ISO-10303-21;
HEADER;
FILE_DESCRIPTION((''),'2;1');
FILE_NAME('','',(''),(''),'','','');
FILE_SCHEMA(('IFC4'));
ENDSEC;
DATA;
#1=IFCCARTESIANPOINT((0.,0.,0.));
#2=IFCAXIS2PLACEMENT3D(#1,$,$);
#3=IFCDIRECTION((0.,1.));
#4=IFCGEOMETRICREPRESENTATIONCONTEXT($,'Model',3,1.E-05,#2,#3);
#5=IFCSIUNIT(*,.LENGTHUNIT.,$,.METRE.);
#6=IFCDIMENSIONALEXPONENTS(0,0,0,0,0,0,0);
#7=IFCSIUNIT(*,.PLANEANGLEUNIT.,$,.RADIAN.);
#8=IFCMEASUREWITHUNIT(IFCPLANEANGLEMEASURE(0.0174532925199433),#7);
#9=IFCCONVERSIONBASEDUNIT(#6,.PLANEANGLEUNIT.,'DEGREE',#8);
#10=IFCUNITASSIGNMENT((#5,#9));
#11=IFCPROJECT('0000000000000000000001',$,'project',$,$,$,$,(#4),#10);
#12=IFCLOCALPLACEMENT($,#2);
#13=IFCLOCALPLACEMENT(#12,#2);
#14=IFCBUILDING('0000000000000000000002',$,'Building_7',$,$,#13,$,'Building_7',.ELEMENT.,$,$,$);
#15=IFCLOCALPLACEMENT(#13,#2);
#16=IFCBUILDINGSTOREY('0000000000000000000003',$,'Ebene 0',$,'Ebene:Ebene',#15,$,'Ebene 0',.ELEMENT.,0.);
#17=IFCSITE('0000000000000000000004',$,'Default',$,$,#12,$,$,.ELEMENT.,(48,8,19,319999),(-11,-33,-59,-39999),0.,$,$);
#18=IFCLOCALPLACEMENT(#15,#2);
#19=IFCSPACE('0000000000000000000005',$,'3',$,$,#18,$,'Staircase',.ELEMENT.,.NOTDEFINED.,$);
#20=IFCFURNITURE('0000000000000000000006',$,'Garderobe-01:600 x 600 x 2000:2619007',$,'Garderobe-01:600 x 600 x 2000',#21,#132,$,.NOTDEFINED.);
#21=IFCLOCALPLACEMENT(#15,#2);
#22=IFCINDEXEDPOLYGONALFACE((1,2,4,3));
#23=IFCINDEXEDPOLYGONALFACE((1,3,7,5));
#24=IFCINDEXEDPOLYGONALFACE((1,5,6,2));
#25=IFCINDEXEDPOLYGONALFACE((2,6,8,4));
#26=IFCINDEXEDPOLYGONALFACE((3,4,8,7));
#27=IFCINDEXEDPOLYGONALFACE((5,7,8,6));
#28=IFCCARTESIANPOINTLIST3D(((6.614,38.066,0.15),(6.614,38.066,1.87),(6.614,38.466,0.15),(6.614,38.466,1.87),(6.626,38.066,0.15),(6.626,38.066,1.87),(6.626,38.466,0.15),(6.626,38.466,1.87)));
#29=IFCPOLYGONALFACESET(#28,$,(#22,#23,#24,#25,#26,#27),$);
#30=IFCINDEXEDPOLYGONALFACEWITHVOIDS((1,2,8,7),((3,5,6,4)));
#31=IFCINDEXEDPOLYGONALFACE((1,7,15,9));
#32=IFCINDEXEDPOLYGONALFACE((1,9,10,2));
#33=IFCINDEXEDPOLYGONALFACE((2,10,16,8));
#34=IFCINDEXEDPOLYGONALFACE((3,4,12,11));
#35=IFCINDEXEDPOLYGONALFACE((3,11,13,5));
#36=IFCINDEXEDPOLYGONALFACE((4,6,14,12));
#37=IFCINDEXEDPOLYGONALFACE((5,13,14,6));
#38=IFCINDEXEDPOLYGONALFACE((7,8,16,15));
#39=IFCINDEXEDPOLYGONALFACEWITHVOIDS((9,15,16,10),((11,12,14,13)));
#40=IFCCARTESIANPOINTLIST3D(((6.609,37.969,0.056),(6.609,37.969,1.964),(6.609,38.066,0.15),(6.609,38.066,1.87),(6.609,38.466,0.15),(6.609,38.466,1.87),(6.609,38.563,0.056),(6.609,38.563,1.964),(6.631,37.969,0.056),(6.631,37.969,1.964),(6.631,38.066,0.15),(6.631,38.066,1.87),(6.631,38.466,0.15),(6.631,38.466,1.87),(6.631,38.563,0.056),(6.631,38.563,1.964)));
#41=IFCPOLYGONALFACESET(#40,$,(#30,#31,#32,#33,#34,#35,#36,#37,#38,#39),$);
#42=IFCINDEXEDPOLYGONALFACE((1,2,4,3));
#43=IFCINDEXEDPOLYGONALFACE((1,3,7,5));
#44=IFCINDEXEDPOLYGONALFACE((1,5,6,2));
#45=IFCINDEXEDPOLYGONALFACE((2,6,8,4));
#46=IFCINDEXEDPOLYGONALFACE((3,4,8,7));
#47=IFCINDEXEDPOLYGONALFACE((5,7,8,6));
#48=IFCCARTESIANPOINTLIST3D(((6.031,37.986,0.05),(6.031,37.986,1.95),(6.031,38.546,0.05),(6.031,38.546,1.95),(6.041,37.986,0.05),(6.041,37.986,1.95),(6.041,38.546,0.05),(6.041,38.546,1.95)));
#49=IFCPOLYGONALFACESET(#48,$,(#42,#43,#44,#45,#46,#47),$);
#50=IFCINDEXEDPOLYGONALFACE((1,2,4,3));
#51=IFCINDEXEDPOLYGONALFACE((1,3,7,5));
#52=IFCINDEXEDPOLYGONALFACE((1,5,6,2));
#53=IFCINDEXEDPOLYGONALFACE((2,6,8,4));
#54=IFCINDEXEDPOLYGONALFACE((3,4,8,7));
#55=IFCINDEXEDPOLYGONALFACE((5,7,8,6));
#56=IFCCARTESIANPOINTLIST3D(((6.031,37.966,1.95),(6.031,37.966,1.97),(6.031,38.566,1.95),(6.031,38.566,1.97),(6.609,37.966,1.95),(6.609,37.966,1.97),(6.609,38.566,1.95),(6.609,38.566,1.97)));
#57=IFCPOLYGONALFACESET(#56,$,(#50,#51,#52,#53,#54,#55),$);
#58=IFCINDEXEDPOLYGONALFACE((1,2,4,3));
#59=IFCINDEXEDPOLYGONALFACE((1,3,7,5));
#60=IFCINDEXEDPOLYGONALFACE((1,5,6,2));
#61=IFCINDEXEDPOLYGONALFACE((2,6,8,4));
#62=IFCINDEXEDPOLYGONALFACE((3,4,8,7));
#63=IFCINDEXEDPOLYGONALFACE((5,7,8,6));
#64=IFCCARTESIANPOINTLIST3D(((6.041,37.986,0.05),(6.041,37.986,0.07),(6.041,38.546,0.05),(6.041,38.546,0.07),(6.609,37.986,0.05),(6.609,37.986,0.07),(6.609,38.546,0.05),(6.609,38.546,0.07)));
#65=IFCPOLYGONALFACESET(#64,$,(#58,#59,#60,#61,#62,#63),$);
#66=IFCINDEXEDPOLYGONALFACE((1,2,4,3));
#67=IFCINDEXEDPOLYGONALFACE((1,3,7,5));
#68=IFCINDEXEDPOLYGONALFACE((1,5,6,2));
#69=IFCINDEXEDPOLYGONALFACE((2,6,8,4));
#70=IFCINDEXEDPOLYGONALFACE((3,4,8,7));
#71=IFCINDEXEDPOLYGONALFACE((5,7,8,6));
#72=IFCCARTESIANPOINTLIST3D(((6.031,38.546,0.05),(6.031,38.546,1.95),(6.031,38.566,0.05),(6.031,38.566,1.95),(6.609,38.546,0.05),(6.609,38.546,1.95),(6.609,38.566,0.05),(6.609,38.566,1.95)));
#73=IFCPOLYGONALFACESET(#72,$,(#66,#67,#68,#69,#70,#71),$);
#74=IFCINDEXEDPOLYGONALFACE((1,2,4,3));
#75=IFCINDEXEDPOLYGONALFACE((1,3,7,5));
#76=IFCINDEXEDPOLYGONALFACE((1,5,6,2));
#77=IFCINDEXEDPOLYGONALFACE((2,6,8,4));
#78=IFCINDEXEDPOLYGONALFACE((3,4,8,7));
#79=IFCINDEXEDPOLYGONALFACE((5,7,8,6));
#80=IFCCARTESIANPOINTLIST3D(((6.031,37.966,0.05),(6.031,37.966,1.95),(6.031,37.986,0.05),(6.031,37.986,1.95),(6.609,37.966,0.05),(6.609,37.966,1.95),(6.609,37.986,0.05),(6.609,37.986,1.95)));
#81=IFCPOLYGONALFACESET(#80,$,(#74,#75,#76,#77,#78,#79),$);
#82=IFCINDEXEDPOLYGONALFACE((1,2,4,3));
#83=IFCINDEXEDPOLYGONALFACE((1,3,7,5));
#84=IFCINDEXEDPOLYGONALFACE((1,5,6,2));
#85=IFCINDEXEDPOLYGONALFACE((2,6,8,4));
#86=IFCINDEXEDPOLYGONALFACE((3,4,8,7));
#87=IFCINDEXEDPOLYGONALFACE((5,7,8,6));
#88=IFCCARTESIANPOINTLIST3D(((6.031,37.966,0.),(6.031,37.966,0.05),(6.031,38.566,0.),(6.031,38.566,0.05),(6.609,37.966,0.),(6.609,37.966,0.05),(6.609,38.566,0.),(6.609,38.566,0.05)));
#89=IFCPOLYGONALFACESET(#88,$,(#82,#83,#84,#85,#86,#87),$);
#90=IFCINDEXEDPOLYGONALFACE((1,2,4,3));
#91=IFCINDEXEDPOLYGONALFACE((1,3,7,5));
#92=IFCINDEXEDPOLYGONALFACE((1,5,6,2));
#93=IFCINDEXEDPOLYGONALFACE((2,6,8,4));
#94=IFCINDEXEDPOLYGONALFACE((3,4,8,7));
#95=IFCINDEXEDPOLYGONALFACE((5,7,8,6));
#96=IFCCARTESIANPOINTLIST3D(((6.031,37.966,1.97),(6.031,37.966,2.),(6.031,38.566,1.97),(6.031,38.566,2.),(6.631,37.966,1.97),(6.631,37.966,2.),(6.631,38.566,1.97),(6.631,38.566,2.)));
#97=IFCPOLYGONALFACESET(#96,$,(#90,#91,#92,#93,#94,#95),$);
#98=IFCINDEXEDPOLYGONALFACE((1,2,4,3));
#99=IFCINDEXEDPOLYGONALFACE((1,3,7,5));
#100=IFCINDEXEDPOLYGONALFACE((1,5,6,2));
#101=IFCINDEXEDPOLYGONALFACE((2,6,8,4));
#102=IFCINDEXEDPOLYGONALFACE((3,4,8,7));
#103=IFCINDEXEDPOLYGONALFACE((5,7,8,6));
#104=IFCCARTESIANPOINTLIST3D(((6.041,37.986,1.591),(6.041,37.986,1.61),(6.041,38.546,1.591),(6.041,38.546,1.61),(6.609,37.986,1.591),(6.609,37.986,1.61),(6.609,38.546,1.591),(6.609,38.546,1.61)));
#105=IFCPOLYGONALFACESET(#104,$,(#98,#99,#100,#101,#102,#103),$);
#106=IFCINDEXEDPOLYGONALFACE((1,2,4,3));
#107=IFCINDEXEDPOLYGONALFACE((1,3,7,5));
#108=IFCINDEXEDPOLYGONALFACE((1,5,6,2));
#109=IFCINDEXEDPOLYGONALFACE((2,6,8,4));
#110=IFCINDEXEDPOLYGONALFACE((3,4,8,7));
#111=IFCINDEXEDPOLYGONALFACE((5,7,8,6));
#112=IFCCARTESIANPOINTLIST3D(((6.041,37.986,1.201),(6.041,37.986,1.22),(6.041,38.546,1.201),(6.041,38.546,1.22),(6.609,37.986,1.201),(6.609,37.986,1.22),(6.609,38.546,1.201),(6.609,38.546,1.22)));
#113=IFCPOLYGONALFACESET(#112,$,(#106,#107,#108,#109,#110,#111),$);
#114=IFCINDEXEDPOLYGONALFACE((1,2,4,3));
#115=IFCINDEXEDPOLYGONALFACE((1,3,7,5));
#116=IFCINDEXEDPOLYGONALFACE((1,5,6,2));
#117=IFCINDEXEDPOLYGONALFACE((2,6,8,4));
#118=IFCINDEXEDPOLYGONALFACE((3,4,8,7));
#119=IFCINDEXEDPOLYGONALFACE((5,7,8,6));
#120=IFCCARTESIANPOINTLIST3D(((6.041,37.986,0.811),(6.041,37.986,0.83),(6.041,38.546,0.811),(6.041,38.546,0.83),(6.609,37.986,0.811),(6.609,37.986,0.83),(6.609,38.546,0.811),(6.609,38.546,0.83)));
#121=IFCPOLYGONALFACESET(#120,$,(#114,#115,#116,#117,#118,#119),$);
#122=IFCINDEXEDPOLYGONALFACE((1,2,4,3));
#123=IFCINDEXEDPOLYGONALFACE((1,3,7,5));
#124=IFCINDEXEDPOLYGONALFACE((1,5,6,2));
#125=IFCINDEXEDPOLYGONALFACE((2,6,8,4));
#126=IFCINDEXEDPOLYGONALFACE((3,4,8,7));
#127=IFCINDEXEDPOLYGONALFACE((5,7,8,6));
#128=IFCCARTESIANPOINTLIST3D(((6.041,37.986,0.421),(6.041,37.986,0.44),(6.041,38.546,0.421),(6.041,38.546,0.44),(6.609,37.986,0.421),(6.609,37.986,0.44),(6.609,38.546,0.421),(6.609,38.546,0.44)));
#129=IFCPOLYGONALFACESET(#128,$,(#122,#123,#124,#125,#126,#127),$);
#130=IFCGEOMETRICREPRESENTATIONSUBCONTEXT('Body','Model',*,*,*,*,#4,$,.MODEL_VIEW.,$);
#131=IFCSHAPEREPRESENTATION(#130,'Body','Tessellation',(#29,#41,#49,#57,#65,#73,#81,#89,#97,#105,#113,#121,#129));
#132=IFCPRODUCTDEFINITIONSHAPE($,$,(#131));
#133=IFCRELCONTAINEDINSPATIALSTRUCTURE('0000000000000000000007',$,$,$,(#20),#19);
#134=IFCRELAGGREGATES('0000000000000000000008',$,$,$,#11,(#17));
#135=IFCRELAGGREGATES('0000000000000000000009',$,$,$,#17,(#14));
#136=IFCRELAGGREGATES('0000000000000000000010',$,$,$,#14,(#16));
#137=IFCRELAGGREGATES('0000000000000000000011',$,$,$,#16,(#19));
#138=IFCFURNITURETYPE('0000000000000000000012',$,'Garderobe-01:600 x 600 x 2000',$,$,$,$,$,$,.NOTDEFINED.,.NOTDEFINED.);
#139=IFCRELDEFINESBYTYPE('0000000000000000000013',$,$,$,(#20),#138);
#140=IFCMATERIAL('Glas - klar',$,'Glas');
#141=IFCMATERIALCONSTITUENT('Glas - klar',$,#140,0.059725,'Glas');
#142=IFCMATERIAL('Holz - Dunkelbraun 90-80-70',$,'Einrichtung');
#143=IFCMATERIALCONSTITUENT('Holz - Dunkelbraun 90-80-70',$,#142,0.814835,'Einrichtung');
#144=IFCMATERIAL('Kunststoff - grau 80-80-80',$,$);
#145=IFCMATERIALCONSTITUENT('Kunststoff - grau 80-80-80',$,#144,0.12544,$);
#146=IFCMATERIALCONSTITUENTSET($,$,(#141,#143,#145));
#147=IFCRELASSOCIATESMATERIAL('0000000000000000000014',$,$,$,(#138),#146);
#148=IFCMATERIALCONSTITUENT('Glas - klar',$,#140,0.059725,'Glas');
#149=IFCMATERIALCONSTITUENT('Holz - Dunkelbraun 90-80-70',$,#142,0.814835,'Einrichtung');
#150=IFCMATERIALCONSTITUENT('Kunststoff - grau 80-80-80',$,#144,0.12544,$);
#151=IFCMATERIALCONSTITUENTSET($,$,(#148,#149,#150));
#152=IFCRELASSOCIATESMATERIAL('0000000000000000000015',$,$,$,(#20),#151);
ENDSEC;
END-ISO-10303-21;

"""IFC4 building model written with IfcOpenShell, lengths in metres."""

from ifc_helpers import new_model, entity, si_unit, converted_unit, direction, frame, origin, place, context, subcontext, project, spatial, indexed_curve, outline, extrude, source, transform, mapped, material, constituent, constituent_set, type_object, type_shapes, element, save


model = new_model("IFC4")

# Units and contexts
model_context = context("Model", 3, precision=1e-05, world=origin(), true_north=direction((0.0, 1.0)))
body_context = subcontext(model_context, "Body", "Model", "MODEL_VIEW")
ifc_project = project(units=[si_unit("LENGTHUNIT", "METRE"), converted_unit("PLANEANGLEUNIT", "DEGREE", entity("IfcPlaneAngleMeasure", 0.0174532925199433), si_unit("PLANEANGLEUNIT", "RADIAN"), dimensions=[0, 0, 0, 0, 0, 0, 0])], contexts=[model_context])

# Site, building, storey
site_placement = place(None, origin())
site = spatial("IfcSite", under=ifc_project, at=site_placement, Name="Default", CompositionType="ELEMENT", RefLatitude=(48, 8, 19, 319999), RefLongitude=(-11, -33, -59, -39999), RefElevation=0.0)
building_placement = place(site_placement, origin())
building = spatial("IfcBuilding", under=site, at=building_placement, Name="Building_7", LongName="Building_7", CompositionType="ELEMENT")
storey_placement = place(building_placement, origin())
storey = spatial("IfcBuildingStorey", under=building, at=storey_placement, Name="Ebene 0", ObjectType="Ebene:Ebene", LongName="Ebene 0", CompositionType="ELEMENT", Elevation=0.0)

# Shared definitions
ifc_material_1 = material(Name="Glas - klar", Category="Glas")
ifc_material_2 = material(Name="Holz - Dunkelbraun 90-80-70", Category="Einrichtung")
ifc_material_3 = material(Name="Kunststoff - grau 80-80-80")
ifc_constituent_1 = constituent(ifc_material_1, Name="Glas - klar", Category="Glas", fraction=0.059725)
ifc_constituent_2 = constituent(ifc_material_2, Name="Holz - Dunkelbraun 90-80-70", Category="Einrichtung", fraction=0.814835)
ifc_constituent_3 = constituent(ifc_material_3, Name="Kunststoff - grau 80-80-80", fraction=0.12544)
ifc_constituent_set_1 = constituent_set(constituents=[ifc_constituent_1, ifc_constituent_2, ifc_constituent_3])
furniture_type_1 = type_object("IfcFurnitureType", Name="Garderobe-01:600 x 600 x 2000", AssemblyPlace="NOTDEFINED", PredefinedType="NOTDEFINED", material=ifc_constituent_set_1)
shared_shape_1 = source(origin(), body_context, "Body", "SweptSolid", [
    extrude(outline(indexed_curve([(-0.006, -0.2), (0.006, -0.2), (0.006, 0.2), (-0.006, 0.2), (-0.006, -0.2)], self_intersect=False)), frame((0.0, -0.289, 0.15), z_axis=(0.0, 0.0, 1.0), x_axis=(0.0, 1.0, 0.0)), (0.0, 0.0, 1.0), 1.72),
    extrude(outline(indexed_curve([(-0.954, -0.297), (0.954, -0.297), (0.954, 0.297), (-0.954, 0.297), (-0.954, -0.297)], self_intersect=False), holes=[indexed_curve([(-0.86, 0.2), (0.86, 0.2), (0.86, -0.2), (-0.86, -0.2), (-0.86, 0.2)], self_intersect=False)]), frame((0.0, -0.3, 1.01), z_axis=(0.0, 1.0, 0.0), x_axis=(0.0, 0.0, -1.0)), (0.0, 0.0, 1.0), 0.022),
    extrude(outline(indexed_curve([(-0.28, -0.005), (0.28, -0.005), (0.28, 0.005), (-0.28, 0.005), (-0.28, -0.005)], self_intersect=False)), frame((0.0, 0.295, 0.05), z_axis=(0.0, 0.0, 1.0), x_axis=(-1.0, 0.0, 0.0)), (0.0, 0.0, 1.0), 1.9),
    extrude(outline(indexed_curve([(-0.3, -0.289), (0.3, -0.289), (0.3, 0.289), (-0.3, 0.289), (-0.3, -0.289)], self_intersect=False)), frame((0.0, 0.011, 1.95), z_axis=(0.0, 0.0, 1.0), x_axis=(-1.0, 0.0, 0.0)), (0.0, 0.0, 1.0), 0.02),
    extrude(outline(indexed_curve([(-0.28, -0.284), (0.28, -0.284), (0.28, 0.284), (-0.28, 0.284), (-0.28, -0.284)], self_intersect=False)), frame((0.0, 0.006, 0.05), z_axis=(0.0, 0.0, 1.0), x_axis=(-1.0, 0.0, 0.0)), (0.0, 0.0, 1.0), 0.02),
    extrude(outline(indexed_curve([(-0.01, -0.289), (0.01, -0.289), (0.01, 0.289), (-0.01, 0.289), (-0.01, -0.289)], self_intersect=False)), frame((0.29, 0.011, 0.05), z_axis=(0.0, 0.0, 1.0), x_axis=(-1.0, 0.0, 0.0)), (0.0, 0.0, 1.0), 1.9),
    extrude(outline(indexed_curve([(-0.01, -0.289), (0.01, -0.289), (0.01, 0.289), (-0.01, 0.289), (-0.01, -0.289)], self_intersect=False)), frame((-0.29, 0.011, 0.05), z_axis=(0.0, 0.0, 1.0), x_axis=(-1.0, 0.0, 0.0)), (0.0, 0.0, 1.0), 1.9),
    extrude(outline(indexed_curve([(-0.3, -0.289), (0.3, -0.289), (0.3, 0.289), (-0.3, 0.289), (-0.3, -0.289)], self_intersect=False)), frame((0.0, 0.011, 0.0), z_axis=(0.0, 0.0, 1.0), x_axis=(-1.0, 0.0, 0.0)), (0.0, 0.0, 1.0), 0.05),
    extrude(outline(indexed_curve([(-0.3, -0.3), (0.3, -0.3), (0.3, 0.3), (-0.3, 0.3), (-0.3, -0.3)], self_intersect=False)), frame((0.0, 0.0, 1.97), z_axis=(0.0, 0.0, 1.0), x_axis=(-1.0, 0.0, 0.0)), (0.0, 0.0, 1.0), 0.03),
    extrude(outline(indexed_curve([(-0.28, -0.284), (0.28, -0.284), (0.28, 0.284), (-0.28, 0.284), (-0.28, -0.284)], self_intersect=False)), frame((0.0, 0.006, 1.591), z_axis=(0.0, 0.0, 1.0), x_axis=(-1.0, 0.0, 0.0)), (0.0, 0.0, 1.0), 0.019),
    extrude(outline(indexed_curve([(-0.28, -0.284), (0.28, -0.284), (0.28, 0.284), (-0.28, 0.284), (-0.28, -0.284)], self_intersect=False)), frame((0.0, 0.006, 1.201), z_axis=(0.0, 0.0, 1.0), x_axis=(-1.0, 0.0, 0.0)), (0.0, 0.0, 1.0), 0.019),
    extrude(outline(indexed_curve([(-0.28, -0.284), (0.28, -0.284), (0.28, 0.284), (-0.28, 0.284), (-0.28, -0.284)], self_intersect=False)), frame((0.0, 0.006, 0.811), z_axis=(0.0, 0.0, 1.0), x_axis=(-1.0, 0.0, 0.0)), (0.0, 0.0, 1.0), 0.019),
    extrude(outline(indexed_curve([(-0.28, -0.284), (0.28, -0.284), (0.28, 0.284), (-0.28, 0.284), (-0.28, -0.284)], self_intersect=False)), frame((0.0, 0.006, 0.421), z_axis=(0.0, 0.0, 1.0), x_axis=(-1.0, 0.0, 0.0)), (0.0, 0.0, 1.0), 0.019),
])
type_shapes(furniture_type_1, [shared_shape_1])

# Shared definitions
space_1_placement = place(storey_placement, origin())
space_1 = spatial("IfcSpace", under=storey, at=space_1_placement, Name="3", LongName="Staircase", CompositionType="ELEMENT", PredefinedType="NOTDEFINED")

# Furniture
ifc_constituent_4 = constituent(ifc_material_1, Name="Glas - klar", Category="Glas", fraction=0.059725)
ifc_constituent_5 = constituent(ifc_material_2, Name="Holz - Dunkelbraun 90-80-70", Category="Einrichtung", fraction=0.814835)
ifc_constituent_6 = constituent(ifc_material_3, Name="Kunststoff - grau 80-80-80", fraction=0.12544)
ifc_constituent_set_2 = constituent_set(constituents=[ifc_constituent_4, ifc_constituent_5, ifc_constituent_6])
furniture_1_placement = place(space_1_placement, frame((6.331, 38.266, 0.0), z_axis=(0.0, 0.0, 1.0), x_axis=(0.0, 1.0, 0.0)))
element("IfcFurniture", 1, at=furniture_1_placement, inside=space_1, type_object=furniture_type_1, material=ifc_constituent_set_2, Name="Garderobe-01:600 x 600 x 2000:2619007", ObjectType="Garderobe-01:600 x 600 x 2000", PredefinedType="NOTDEFINED", context=body_context, shape_type="MappedRepresentation", body=[
    mapped(shared_shape_1, transform((0.0, 0.0, 0.0), scale=1.0)),
])

save(model, "model.ifc")
